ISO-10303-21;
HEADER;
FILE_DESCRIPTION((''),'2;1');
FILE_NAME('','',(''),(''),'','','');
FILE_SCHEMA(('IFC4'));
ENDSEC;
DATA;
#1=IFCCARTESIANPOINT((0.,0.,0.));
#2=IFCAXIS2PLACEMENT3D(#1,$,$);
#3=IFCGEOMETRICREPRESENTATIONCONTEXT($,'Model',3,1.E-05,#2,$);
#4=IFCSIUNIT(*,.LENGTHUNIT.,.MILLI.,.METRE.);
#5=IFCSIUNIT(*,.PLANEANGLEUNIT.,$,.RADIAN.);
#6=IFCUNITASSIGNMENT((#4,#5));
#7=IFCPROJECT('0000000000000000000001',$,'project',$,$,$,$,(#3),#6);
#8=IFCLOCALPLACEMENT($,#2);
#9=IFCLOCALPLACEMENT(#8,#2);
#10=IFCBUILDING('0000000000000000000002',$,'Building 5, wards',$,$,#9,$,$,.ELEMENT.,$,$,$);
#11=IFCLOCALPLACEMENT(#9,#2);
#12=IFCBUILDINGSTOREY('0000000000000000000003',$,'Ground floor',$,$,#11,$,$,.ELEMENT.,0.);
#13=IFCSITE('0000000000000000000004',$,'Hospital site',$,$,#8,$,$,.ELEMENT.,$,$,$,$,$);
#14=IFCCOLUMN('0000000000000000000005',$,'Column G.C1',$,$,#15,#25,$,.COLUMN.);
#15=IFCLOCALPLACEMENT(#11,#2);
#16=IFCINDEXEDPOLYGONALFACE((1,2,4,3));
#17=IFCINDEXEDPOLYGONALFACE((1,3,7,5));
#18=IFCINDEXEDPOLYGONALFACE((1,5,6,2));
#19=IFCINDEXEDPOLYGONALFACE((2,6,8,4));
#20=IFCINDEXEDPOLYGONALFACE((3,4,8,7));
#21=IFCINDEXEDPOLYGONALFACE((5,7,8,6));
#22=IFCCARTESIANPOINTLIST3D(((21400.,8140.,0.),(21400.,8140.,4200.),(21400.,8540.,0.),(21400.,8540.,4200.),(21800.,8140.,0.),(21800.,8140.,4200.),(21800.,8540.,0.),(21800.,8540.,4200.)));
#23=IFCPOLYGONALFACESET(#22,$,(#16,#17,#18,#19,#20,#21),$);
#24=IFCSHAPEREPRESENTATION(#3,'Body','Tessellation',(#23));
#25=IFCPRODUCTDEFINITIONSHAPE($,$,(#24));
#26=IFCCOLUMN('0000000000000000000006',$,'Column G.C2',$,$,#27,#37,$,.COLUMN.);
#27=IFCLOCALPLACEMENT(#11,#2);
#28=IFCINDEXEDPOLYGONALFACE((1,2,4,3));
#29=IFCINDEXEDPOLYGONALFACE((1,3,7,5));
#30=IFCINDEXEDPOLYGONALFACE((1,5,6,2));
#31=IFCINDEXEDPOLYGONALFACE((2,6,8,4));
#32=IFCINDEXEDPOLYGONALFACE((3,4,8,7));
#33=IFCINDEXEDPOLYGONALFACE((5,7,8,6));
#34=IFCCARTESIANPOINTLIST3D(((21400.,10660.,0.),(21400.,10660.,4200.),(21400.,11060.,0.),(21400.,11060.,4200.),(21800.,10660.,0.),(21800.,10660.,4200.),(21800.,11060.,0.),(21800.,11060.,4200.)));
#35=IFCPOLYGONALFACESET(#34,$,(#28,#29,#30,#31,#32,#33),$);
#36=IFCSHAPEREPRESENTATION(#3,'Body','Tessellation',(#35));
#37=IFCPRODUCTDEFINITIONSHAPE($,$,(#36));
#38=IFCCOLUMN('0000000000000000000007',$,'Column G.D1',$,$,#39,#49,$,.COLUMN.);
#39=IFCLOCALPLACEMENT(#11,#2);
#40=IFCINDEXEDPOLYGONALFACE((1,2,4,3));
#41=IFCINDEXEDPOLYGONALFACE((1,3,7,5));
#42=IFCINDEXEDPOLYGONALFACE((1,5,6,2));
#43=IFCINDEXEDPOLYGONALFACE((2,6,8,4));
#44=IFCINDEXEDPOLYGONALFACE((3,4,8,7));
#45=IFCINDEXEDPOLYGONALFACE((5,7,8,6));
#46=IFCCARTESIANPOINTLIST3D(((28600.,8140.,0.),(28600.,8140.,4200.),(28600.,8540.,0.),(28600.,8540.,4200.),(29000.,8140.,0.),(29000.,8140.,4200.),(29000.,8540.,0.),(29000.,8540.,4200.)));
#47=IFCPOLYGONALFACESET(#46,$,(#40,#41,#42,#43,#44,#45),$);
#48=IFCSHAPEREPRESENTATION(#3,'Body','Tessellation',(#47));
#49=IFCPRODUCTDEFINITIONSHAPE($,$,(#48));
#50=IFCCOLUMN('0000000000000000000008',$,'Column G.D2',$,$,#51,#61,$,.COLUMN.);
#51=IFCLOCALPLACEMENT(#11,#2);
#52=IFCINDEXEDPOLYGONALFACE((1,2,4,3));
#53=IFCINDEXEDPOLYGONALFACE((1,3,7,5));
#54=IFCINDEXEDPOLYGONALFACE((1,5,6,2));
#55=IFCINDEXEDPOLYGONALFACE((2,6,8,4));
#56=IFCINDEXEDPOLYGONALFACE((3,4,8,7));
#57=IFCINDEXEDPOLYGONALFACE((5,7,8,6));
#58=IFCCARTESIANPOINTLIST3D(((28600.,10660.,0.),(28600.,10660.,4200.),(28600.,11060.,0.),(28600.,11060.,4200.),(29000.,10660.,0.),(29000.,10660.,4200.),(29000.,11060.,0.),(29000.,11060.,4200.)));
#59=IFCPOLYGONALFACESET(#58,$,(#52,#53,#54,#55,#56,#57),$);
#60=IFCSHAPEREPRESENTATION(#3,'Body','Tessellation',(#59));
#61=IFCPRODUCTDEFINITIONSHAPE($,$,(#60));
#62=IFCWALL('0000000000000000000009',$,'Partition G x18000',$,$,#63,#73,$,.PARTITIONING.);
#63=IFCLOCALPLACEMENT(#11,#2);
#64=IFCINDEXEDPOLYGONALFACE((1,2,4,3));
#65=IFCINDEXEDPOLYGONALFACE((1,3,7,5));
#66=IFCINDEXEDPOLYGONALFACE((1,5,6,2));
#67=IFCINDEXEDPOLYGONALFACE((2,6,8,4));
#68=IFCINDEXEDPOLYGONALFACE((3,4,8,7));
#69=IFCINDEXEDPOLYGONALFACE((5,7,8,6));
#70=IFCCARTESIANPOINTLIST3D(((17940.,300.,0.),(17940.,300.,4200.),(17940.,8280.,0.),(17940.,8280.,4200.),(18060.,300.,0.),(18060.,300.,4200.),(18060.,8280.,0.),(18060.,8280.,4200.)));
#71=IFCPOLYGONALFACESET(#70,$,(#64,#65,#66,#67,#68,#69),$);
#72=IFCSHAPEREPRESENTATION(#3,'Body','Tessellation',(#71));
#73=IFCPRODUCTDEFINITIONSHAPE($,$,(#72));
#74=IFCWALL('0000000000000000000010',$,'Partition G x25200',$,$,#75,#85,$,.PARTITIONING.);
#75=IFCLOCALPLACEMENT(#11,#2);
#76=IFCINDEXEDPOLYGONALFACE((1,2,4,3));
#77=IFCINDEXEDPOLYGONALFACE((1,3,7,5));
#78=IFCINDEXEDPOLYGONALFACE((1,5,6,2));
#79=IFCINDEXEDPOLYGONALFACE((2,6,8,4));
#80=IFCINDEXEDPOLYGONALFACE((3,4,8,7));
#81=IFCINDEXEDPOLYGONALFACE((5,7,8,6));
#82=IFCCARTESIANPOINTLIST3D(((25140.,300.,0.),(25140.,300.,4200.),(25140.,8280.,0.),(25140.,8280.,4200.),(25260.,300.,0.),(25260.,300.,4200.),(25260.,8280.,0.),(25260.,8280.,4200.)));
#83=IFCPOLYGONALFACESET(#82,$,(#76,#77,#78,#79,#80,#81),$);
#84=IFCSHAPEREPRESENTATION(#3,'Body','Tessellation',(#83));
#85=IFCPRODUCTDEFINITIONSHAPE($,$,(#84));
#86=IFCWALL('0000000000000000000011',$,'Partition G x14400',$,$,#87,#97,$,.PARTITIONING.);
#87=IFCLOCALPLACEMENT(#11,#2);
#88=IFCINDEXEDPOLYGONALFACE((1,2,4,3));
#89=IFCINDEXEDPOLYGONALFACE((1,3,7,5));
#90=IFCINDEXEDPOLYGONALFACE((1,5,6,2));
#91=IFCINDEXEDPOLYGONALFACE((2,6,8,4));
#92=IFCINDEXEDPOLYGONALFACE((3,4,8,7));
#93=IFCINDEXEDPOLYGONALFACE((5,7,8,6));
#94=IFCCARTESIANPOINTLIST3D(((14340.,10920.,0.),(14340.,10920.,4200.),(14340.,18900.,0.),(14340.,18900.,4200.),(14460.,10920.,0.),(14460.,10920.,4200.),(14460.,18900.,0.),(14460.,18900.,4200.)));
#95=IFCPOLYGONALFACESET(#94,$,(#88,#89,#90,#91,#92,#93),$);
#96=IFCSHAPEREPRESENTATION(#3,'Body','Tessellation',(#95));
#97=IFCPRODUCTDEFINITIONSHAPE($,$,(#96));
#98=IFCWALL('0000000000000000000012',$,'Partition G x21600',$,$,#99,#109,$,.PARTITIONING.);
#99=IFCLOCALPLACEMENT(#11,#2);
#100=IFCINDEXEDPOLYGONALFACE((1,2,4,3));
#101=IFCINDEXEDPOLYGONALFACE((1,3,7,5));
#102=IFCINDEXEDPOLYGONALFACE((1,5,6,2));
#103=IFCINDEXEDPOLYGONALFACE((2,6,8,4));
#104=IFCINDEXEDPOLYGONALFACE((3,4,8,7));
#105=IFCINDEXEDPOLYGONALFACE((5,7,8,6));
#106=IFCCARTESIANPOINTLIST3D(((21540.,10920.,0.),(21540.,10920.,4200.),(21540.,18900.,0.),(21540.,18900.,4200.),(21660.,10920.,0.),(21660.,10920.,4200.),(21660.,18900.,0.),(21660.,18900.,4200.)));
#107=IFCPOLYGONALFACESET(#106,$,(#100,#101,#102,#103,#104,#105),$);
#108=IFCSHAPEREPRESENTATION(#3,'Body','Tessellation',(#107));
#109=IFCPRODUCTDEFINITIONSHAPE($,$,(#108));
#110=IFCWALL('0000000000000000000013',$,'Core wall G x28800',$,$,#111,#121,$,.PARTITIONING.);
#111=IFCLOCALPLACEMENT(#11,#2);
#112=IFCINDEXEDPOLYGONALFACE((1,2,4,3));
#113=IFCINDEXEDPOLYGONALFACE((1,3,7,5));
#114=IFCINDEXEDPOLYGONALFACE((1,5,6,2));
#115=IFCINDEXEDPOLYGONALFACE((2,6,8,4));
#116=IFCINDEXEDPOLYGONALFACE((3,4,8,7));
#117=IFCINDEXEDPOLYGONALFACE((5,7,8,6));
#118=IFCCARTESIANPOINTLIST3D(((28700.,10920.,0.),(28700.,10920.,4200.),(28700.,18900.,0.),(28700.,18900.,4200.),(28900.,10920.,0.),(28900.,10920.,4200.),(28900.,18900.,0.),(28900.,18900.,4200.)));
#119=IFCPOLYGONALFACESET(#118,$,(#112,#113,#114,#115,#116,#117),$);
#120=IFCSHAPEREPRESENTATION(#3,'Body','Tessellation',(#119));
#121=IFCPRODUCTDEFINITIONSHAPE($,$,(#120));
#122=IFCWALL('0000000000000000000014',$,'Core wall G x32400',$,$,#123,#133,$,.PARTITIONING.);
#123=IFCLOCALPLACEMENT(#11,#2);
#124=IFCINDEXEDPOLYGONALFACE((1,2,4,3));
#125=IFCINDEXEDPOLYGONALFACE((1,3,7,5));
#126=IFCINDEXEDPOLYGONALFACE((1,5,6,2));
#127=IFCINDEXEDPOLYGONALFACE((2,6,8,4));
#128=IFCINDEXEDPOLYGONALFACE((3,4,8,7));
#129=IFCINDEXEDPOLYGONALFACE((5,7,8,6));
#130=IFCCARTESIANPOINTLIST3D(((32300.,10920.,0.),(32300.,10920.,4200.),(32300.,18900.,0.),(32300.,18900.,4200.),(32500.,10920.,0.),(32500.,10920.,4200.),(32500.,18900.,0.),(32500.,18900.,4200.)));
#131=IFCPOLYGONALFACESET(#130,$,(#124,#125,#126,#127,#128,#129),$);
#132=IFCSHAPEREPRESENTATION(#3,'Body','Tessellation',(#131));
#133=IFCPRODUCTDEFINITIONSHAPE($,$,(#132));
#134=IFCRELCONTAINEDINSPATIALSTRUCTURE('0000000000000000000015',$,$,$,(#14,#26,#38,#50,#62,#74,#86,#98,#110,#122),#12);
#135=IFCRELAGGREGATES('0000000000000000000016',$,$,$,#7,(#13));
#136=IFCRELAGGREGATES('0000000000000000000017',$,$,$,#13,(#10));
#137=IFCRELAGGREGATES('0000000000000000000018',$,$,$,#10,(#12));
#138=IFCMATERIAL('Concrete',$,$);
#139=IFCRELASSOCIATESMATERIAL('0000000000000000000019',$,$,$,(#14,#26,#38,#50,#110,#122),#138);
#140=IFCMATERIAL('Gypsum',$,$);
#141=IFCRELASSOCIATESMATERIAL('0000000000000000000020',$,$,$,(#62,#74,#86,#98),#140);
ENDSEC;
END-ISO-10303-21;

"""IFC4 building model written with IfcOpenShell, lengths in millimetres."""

from ifc_helpers import new_model, si_unit, frame, frame_2d, origin, origin_2d, place, context, project, spatial, rectangle, extrude, material, element, save


model = new_model("IFC4")

# Units and contexts
model_context = context("Model", 3, precision=1e-05, world=origin())
ifc_project = project(units=[si_unit("LENGTHUNIT", "METRE", prefix="MILLI"), si_unit("PLANEANGLEUNIT", "RADIAN")], contexts=[model_context])

# Site, building, storey
site_placement = place(None, origin())
site = spatial("IfcSite", under=ifc_project, at=site_placement, Name="Hospital site", CompositionType="ELEMENT")
building_placement = place(site_placement, origin())
building = spatial("IfcBuilding", under=site, at=building_placement, Name="Building 5, wards", CompositionType="ELEMENT")
storey_placement = place(building_placement, origin())
storey = spatial("IfcBuildingStorey", under=building, at=storey_placement, Name="Ground floor", CompositionType="ELEMENT", Elevation=0.0)

# Columns
ifc_material_1 = material(Name="Concrete")
for number, where, name in (
    (1, (21600.0, 8340.0, 0.0), "Column G.C1"),
    (2, (21600.0, 10860.0, 0.0), "Column G.C2"),
    (3, (28800.0, 8340.0, 0.0), "Column G.D1"),
    (4, (28800.0, 10860.0, 0.0), "Column G.D2"),
):
    element("IfcColumn", number, at=place(storey_placement, frame(where)), inside=storey, material=ifc_material_1, Name=name, PredefinedType="COLUMN", context=model_context, shape_type="SweptSolid", body=[
        extrude(rectangle(XDim=400.0, YDim=400.0, at=origin_2d()), origin(), (0.0, 0.0, 1.0), 4200.0),
    ])

# Walls
ifc_material_2 = material(Name="Gypsum")
for number, where, x_axis, name in (
    (5, (18060.0, 300.0, 0.0), (0.0, 1.0, 0.0), "Partition G x18000"),
    (6, (25260.0, 300.0, 0.0), (0.0, 1.0, 0.0), "Partition G x25200"),
    (7, (14460.0, 10920.0, 0.0), (0.0, 1.0, 0.0), "Partition G x14400"),
    (8, (21660.0, 10920.0, 0.0), (0.0, 1.0, 0.0), "Partition G x21600"),
):
    element("IfcWall", number, at=place(storey_placement, frame(where, x_axis=x_axis)), inside=storey, material=ifc_material_2, Name=name, PredefinedType="PARTITIONING", context=model_context, shape_type="SweptSolid", body=[
        extrude(rectangle(XDim=7980.0, YDim=120.0, at=frame_2d((3990.0, 60.0))), origin(), (0.0, 0.0, 1.0), 4200.0),
    ])
for number, where, x_axis, name in (
    (9, (28900.0, 10920.0, 0.0), (0.0, 1.0, 0.0), "Core wall G x28800"),
    (10, (32500.0, 10920.0, 0.0), (0.0, 1.0, 0.0), "Core wall G x32400"),
):
    element("IfcWall", number, at=place(storey_placement, frame(where, x_axis=x_axis)), inside=storey, material=ifc_material_1, Name=name, PredefinedType="PARTITIONING", context=model_context, shape_type="SweptSolid", body=[
        extrude(rectangle(XDim=7980.0, YDim=200.0, at=frame_2d((3990.0, 100.0))), origin(), (0.0, 0.0, 1.0), 4200.0),
    ])

save(model, "model.ifc")
